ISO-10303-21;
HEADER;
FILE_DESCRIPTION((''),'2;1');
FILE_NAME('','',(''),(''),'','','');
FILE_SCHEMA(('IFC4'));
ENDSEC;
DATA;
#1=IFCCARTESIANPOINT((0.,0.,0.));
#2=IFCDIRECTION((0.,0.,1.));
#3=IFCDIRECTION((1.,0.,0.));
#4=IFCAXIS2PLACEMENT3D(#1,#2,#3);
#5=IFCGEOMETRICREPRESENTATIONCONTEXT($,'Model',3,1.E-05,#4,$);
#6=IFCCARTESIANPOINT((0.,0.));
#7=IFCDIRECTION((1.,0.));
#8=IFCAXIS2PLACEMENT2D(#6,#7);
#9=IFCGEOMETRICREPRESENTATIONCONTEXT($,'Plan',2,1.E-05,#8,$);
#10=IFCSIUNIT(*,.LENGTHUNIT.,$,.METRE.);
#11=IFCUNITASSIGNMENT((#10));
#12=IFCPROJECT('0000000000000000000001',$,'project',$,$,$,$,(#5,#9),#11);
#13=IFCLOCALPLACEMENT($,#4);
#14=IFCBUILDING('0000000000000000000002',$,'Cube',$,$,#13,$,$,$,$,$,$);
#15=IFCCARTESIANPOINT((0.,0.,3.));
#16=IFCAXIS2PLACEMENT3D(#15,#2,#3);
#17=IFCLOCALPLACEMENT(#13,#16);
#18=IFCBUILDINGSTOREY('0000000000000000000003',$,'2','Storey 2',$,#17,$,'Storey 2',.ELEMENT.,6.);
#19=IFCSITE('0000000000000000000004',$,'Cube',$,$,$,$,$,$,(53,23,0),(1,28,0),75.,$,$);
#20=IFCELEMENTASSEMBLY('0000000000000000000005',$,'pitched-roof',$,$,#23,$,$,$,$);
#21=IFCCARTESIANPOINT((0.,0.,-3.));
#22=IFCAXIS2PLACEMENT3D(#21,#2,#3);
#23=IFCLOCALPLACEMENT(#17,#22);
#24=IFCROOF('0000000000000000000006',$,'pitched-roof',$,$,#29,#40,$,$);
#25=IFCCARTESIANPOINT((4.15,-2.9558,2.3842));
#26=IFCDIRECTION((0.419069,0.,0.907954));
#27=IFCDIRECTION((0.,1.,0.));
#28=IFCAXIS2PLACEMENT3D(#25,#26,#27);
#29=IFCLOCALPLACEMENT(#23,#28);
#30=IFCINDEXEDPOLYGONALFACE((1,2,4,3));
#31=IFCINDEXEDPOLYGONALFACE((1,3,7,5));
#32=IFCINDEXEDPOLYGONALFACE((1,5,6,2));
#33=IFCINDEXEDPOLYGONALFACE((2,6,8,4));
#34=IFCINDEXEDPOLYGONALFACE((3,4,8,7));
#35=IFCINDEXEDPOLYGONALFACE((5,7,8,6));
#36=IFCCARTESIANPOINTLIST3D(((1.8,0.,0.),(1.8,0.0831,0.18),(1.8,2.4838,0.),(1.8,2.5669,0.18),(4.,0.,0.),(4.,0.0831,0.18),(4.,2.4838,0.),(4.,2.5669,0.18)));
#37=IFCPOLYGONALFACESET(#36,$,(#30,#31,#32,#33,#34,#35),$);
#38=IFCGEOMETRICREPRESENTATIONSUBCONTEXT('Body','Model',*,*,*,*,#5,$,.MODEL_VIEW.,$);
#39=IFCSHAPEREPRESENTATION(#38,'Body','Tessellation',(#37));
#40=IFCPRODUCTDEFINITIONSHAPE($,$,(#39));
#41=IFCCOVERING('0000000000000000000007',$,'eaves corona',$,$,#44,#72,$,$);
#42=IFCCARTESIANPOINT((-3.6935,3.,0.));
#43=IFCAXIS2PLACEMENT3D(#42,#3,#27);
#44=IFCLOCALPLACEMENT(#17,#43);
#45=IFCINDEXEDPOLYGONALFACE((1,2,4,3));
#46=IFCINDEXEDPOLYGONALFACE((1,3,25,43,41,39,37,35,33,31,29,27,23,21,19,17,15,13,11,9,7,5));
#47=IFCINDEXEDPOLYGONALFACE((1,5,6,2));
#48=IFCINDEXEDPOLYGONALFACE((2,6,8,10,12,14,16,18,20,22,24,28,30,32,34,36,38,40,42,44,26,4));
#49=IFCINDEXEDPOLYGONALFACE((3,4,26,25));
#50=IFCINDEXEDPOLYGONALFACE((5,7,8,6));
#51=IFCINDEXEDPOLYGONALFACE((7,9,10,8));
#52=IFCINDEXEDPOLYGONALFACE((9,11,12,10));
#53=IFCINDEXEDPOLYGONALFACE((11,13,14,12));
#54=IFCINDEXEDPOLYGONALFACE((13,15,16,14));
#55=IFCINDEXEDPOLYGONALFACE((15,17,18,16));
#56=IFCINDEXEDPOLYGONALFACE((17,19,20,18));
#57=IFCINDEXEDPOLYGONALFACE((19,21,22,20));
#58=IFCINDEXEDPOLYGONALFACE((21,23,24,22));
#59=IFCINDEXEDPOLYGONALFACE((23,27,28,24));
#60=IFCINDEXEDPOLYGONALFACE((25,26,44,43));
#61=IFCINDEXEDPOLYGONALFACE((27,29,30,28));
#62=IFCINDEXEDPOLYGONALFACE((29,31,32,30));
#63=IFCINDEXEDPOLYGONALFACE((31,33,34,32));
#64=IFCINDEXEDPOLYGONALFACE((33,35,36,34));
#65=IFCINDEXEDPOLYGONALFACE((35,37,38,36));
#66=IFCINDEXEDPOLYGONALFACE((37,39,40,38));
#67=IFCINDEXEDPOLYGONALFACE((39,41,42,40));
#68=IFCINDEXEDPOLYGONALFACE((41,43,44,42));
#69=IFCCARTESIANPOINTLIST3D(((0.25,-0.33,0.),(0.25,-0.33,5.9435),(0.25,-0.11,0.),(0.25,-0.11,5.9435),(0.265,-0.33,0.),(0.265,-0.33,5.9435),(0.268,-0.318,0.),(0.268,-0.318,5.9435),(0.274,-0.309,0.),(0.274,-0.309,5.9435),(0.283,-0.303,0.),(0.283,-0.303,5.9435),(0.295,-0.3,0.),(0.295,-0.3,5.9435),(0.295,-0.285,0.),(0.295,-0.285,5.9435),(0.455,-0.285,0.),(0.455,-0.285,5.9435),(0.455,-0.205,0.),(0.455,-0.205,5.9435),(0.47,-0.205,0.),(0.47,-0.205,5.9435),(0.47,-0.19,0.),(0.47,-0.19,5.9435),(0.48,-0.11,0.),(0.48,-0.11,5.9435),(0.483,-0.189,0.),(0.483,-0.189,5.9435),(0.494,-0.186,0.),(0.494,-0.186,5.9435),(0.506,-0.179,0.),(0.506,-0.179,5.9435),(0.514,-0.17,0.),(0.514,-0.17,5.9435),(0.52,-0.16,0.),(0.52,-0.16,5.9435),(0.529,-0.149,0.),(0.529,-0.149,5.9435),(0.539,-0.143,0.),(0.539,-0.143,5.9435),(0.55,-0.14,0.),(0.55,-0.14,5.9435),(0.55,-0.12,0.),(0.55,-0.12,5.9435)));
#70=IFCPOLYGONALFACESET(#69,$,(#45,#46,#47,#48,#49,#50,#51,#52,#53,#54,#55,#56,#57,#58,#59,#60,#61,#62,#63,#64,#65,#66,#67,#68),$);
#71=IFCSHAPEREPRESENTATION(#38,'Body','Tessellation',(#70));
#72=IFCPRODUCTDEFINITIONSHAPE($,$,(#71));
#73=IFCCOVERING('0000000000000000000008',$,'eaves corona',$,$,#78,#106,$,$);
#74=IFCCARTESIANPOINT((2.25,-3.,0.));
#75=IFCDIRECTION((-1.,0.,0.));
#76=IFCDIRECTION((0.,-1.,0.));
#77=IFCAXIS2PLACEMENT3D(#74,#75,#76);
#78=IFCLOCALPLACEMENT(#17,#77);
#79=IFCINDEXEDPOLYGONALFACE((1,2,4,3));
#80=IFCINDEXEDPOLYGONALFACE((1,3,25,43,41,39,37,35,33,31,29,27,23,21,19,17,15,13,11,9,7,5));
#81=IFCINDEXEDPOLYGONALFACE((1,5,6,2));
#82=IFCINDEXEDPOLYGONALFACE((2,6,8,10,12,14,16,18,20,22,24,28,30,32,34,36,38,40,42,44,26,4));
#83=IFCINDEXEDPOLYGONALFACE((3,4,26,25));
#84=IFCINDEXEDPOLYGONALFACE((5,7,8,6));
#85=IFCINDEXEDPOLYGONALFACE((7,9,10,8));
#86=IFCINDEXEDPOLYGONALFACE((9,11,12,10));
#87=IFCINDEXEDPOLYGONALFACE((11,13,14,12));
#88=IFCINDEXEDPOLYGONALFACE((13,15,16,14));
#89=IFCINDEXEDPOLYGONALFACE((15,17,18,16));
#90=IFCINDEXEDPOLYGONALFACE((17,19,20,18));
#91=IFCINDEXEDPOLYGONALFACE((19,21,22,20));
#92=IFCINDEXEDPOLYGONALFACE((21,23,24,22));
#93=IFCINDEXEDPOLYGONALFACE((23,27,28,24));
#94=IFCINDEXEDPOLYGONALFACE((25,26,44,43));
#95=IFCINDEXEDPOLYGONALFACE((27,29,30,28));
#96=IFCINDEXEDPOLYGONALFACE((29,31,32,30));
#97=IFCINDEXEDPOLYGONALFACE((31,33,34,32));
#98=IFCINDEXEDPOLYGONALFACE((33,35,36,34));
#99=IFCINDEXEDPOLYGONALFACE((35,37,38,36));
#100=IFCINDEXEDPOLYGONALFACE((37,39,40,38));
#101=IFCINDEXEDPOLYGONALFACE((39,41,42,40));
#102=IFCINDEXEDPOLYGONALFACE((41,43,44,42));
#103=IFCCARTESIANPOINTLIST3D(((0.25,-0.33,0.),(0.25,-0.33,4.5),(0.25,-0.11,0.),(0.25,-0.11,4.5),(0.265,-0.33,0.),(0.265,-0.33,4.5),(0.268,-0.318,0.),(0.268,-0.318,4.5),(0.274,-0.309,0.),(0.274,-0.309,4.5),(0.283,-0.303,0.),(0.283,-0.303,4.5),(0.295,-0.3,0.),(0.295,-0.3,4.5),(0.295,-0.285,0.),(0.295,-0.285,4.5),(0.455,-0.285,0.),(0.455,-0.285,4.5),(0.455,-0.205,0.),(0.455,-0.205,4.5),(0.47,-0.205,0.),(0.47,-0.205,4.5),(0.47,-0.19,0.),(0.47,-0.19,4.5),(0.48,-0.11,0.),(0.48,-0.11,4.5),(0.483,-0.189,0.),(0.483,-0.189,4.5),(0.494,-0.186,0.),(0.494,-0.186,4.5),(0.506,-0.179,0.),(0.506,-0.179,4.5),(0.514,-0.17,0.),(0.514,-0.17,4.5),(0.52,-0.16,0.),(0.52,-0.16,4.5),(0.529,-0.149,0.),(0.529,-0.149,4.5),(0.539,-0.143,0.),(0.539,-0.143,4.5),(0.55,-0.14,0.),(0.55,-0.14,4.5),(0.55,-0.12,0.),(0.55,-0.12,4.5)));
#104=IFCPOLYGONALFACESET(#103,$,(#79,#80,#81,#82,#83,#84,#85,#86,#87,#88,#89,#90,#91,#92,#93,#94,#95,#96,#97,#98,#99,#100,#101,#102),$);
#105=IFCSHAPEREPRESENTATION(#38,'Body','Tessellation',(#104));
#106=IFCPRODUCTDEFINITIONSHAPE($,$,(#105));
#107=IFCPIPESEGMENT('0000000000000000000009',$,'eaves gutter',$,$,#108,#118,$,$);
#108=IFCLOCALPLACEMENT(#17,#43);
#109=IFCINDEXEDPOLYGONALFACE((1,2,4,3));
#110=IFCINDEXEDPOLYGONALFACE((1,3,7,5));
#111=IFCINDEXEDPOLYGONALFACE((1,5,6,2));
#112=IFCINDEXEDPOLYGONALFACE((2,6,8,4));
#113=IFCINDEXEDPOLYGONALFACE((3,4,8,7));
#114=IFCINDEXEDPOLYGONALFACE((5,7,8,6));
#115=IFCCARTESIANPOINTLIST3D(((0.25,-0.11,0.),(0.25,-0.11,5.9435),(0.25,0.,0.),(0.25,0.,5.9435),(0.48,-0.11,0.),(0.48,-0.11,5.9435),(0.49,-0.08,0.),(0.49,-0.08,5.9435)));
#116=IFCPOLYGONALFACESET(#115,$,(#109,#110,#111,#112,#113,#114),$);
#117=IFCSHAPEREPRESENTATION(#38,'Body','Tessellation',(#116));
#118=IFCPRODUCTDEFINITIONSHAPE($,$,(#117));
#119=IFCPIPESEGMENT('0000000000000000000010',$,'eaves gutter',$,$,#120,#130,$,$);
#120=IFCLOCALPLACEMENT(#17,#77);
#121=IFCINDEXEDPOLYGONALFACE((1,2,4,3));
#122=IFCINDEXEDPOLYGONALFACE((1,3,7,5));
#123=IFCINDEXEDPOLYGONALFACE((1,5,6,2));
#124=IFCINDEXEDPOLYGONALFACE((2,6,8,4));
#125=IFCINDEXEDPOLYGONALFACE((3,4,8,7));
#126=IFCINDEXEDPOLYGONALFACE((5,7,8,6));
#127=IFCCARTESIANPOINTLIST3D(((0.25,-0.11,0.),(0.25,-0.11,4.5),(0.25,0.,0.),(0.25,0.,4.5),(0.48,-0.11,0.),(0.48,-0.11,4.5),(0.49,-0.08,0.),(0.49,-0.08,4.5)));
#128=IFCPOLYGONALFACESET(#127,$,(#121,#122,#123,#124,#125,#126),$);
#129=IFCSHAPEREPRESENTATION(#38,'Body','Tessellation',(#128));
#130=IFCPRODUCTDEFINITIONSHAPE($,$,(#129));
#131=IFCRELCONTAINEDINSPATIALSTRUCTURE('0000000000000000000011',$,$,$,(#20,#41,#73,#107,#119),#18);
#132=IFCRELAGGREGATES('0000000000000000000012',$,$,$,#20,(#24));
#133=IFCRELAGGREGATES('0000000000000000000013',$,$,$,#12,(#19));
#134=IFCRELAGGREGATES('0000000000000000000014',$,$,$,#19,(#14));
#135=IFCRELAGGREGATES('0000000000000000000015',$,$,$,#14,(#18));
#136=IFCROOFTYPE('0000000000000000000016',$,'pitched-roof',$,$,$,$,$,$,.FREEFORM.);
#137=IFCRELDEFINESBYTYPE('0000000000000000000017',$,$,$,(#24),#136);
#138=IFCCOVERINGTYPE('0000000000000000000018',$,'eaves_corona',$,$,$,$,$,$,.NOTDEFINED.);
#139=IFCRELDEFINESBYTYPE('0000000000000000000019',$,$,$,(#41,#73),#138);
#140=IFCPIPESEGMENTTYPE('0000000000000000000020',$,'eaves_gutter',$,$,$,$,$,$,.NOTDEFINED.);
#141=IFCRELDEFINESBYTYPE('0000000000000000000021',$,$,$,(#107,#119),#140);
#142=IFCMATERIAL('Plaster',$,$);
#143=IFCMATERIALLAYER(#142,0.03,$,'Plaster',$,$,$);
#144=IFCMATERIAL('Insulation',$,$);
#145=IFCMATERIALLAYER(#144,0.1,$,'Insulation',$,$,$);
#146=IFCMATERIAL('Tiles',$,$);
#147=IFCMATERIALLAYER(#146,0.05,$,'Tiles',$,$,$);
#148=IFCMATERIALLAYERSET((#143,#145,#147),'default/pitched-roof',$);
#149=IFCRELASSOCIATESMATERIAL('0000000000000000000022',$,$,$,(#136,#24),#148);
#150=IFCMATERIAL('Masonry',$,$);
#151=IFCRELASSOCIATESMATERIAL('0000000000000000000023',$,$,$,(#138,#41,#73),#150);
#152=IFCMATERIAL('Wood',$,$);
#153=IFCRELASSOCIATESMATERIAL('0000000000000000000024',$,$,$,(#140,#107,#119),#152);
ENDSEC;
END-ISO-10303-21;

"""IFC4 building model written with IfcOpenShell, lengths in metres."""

from ifc_helpers import new_model, si_unit, frame, origin_with_axes, origin_2d_with_axis, place, context, subcontext, project, spatial, polyline, indexed_curve, outline, extrude, material, layer, layer_set, layer_usage, material_profile, profile_set, profile_usage, type_object, element, aggregate, save


model = new_model("IFC4")

# Units and contexts
model_context = context("Model", 3, precision=1e-05, world=origin_with_axes())
plan_context = context("Plan", 2, precision=1e-05, world=origin_2d_with_axis())
body_context = subcontext(model_context, "Body", "Model", "MODEL_VIEW")
ifc_project = project(units=[si_unit("LENGTHUNIT", "METRE")], contexts=[model_context, plan_context])

# Site, building, storey
site = spatial("IfcSite", under=ifc_project, Name="Cube", RefLatitude=(53, 23, 0), RefLongitude=(1, 28, 0), RefElevation=75.0)
building_placement = place(None, origin_with_axes())
building = spatial("IfcBuilding", under=site, at=building_placement, Name="Cube")
storey_placement = place(building_placement, frame((0.0, 0.0, 3.0), z_axis=(0.0, 0.0, 1.0), x_axis=(1.0, 0.0, 0.0)))
storey = spatial("IfcBuildingStorey", under=building, at=storey_placement, Name="2", Description="Storey 2", LongName="Storey 2", CompositionType="ELEMENT", Elevation=6.0)

# Element assembly, roof
assembly_placement = place(storey_placement, frame((0.0, 0.0, -3.0), z_axis=(0.0, 0.0, 1.0), x_axis=(1.0, 0.0, 0.0)))
assembly = element("IfcElementAssembly", 1, at=assembly_placement, inside=storey, Name="pitched-roof")
ifc_material_1 = material(Name="Plaster")
ifc_layer_1 = layer(ifc_material_1, 0.03, Name="Plaster")
ifc_material_2 = material(Name="Insulation")
ifc_layer_2 = layer(ifc_material_2, 0.1, Name="Insulation")
ifc_material_3 = material(Name="Tiles")
ifc_layer_3 = layer(ifc_material_3, 0.05, Name="Tiles")
ifc_layer_set = layer_set([ifc_layer_1, ifc_layer_2, ifc_layer_3], Name="default/pitched-roof")
roof_type = type_object("IfcRoofType", Name="pitched-roof", PredefinedType="FREEFORM", material=ifc_layer_set)
ifc_layer_usage_1 = layer_usage(ifc_layer_set, "AXIS3", "POSITIVE", 0.0)
roof_1_placement = place(assembly_placement, frame((4.15, -2.9558, 2.3842), z_axis=(0.419069, 0.0, 0.907954), x_axis=(0.0, 1.0, 0.0)))
roof_1 = element("IfcRoof", 2, at=roof_1_placement, type_object=roof_type, material=ifc_layer_usage_1, Name="pitched-roof", context=body_context, shape_type="SweptSolid", body=[
    extrude(outline(indexed_curve([(4.0, 2.4838), (4.0, 0.0), (1.8, 0.0), (1.8, 2.4838)])), frame((0.0, 0.0, 0.0), z_axis=(0.0, 0.0, 1.0), x_axis=(1.0, 0.0, 0.0)), (0.0, 0.419069, 0.907954), 0.1982),
])
aggregate(assembly, [roof_1])

# Coverings
ifc_material_4 = material(Name="Masonry")
ifc_material_profile_1 = material_profile(ifc_material_4, outline(polyline([(0.25, -0.11), (0.25, -0.33), (0.265, -0.33), (0.268, -0.318), (0.274, -0.309), (0.283, -0.303), (0.295, -0.3), (0.295, -0.285), (0.455, -0.285), (0.455, -0.205), (0.47, -0.205), (0.47, -0.19), (0.483, -0.189), (0.494, -0.186), (0.506, -0.179), (0.514, -0.17), (0.52, -0.16), (0.529, -0.149), (0.539, -0.143), (0.55, -0.14), (0.55, -0.12), (0.48, -0.11), (0.25, -0.11)])))
ifc_profile_set_1 = profile_set([ifc_material_profile_1])
ifc_profile_usage_1 = profile_usage(ifc_profile_set_1)
covering_type_1 = type_object("IfcCoveringType", Name="eaves_corona", PredefinedType="NOTDEFINED", material=ifc_profile_set_1)
covering_1_placement = place(storey_placement, frame((-3.6935, 3.0, 0.0), z_axis=(1.0, 0.0, 0.0), x_axis=(0.0, 1.0, 0.0)))
element("IfcCovering", 3, at=covering_1_placement, inside=storey, type_object=covering_type_1, material=ifc_profile_usage_1, Name="eaves corona", context=body_context, shape_type="SweptSolid", body=[
    extrude(outline(polyline([(0.25, -0.11), (0.25, -0.33), (0.265, -0.33), (0.268, -0.318), (0.274, -0.309), (0.283, -0.303), (0.295, -0.3), (0.295, -0.285), (0.455, -0.285), (0.455, -0.205), (0.47, -0.205), (0.47, -0.19), (0.483, -0.189), (0.494, -0.186), (0.506, -0.179), (0.514, -0.17), (0.52, -0.16), (0.529, -0.149), (0.539, -0.143), (0.55, -0.14), (0.55, -0.12), (0.48, -0.11), (0.25, -0.11)])), origin_with_axes(), (0.0, 0.0, 1.0), 5.9435),
])
ifc_profile_usage_2 = profile_usage(ifc_profile_set_1)
covering_2_placement = place(storey_placement, frame((2.25, -3.0, 0.0), z_axis=(-1.0, 0.0, 0.0), x_axis=(0.0, -1.0, 0.0)))
element("IfcCovering", 4, at=covering_2_placement, inside=storey, type_object=covering_type_1, material=ifc_profile_usage_2, Name="eaves corona", context=body_context, shape_type="SweptSolid", body=[
    extrude(outline(polyline([(0.25, -0.11), (0.25, -0.33), (0.265, -0.33), (0.268, -0.318), (0.274, -0.309), (0.283, -0.303), (0.295, -0.3), (0.295, -0.285), (0.455, -0.285), (0.455, -0.205), (0.47, -0.205), (0.47, -0.19), (0.483, -0.189), (0.494, -0.186), (0.506, -0.179), (0.514, -0.17), (0.52, -0.16), (0.529, -0.149), (0.539, -0.143), (0.55, -0.14), (0.55, -0.12), (0.48, -0.11), (0.25, -0.11)])), origin_with_axes(), (0.0, 0.0, 1.0), 4.5),
])

# Pipe segments
ifc_material_5 = material(Name="Wood")
ifc_material_profile_2 = material_profile(ifc_material_5, outline(polyline([(0.25, -0.11), (0.48, -0.11), (0.49, -0.08), (0.25, 0.0), (0.25, -0.11)])))
ifc_profile_set_2 = profile_set([ifc_material_profile_2])
ifc_profile_usage_3 = profile_usage(ifc_profile_set_2)
pipe_segment_type = type_object("IfcPipeSegmentType", Name="eaves_gutter", PredefinedType="NOTDEFINED", material=ifc_profile_set_2)
pipe_segment_1_placement = place(storey_placement, frame((-3.6935, 3.0, 0.0), z_axis=(1.0, 0.0, 0.0), x_axis=(0.0, 1.0, 0.0)))
element("IfcPipeSegment", 5, at=pipe_segment_1_placement, inside=storey, type_object=pipe_segment_type, material=ifc_profile_usage_3, Name="eaves gutter", context=body_context, shape_type="SweptSolid", body=[
    extrude(outline(polyline([(0.25, -0.11), (0.48, -0.11), (0.49, -0.08), (0.25, 0.0), (0.25, -0.11)])), origin_with_axes(), (0.0, 0.0, 1.0), 5.9435),
])
ifc_profile_usage_4 = profile_usage(ifc_profile_set_2)
pipe_segment_2_placement = place(storey_placement, frame((2.25, -3.0, 0.0), z_axis=(-1.0, 0.0, 0.0), x_axis=(0.0, -1.0, 0.0)))
element("IfcPipeSegment", 6, at=pipe_segment_2_placement, inside=storey, type_object=pipe_segment_type, material=ifc_profile_usage_4, Name="eaves gutter", context=body_context, shape_type="SweptSolid", body=[
    extrude(outline(polyline([(0.25, -0.11), (0.48, -0.11), (0.49, -0.08), (0.25, 0.0), (0.25, -0.11)])), origin_with_axes(), (0.0, 0.0, 1.0), 4.5),
])

save(model, "model.ifc")
